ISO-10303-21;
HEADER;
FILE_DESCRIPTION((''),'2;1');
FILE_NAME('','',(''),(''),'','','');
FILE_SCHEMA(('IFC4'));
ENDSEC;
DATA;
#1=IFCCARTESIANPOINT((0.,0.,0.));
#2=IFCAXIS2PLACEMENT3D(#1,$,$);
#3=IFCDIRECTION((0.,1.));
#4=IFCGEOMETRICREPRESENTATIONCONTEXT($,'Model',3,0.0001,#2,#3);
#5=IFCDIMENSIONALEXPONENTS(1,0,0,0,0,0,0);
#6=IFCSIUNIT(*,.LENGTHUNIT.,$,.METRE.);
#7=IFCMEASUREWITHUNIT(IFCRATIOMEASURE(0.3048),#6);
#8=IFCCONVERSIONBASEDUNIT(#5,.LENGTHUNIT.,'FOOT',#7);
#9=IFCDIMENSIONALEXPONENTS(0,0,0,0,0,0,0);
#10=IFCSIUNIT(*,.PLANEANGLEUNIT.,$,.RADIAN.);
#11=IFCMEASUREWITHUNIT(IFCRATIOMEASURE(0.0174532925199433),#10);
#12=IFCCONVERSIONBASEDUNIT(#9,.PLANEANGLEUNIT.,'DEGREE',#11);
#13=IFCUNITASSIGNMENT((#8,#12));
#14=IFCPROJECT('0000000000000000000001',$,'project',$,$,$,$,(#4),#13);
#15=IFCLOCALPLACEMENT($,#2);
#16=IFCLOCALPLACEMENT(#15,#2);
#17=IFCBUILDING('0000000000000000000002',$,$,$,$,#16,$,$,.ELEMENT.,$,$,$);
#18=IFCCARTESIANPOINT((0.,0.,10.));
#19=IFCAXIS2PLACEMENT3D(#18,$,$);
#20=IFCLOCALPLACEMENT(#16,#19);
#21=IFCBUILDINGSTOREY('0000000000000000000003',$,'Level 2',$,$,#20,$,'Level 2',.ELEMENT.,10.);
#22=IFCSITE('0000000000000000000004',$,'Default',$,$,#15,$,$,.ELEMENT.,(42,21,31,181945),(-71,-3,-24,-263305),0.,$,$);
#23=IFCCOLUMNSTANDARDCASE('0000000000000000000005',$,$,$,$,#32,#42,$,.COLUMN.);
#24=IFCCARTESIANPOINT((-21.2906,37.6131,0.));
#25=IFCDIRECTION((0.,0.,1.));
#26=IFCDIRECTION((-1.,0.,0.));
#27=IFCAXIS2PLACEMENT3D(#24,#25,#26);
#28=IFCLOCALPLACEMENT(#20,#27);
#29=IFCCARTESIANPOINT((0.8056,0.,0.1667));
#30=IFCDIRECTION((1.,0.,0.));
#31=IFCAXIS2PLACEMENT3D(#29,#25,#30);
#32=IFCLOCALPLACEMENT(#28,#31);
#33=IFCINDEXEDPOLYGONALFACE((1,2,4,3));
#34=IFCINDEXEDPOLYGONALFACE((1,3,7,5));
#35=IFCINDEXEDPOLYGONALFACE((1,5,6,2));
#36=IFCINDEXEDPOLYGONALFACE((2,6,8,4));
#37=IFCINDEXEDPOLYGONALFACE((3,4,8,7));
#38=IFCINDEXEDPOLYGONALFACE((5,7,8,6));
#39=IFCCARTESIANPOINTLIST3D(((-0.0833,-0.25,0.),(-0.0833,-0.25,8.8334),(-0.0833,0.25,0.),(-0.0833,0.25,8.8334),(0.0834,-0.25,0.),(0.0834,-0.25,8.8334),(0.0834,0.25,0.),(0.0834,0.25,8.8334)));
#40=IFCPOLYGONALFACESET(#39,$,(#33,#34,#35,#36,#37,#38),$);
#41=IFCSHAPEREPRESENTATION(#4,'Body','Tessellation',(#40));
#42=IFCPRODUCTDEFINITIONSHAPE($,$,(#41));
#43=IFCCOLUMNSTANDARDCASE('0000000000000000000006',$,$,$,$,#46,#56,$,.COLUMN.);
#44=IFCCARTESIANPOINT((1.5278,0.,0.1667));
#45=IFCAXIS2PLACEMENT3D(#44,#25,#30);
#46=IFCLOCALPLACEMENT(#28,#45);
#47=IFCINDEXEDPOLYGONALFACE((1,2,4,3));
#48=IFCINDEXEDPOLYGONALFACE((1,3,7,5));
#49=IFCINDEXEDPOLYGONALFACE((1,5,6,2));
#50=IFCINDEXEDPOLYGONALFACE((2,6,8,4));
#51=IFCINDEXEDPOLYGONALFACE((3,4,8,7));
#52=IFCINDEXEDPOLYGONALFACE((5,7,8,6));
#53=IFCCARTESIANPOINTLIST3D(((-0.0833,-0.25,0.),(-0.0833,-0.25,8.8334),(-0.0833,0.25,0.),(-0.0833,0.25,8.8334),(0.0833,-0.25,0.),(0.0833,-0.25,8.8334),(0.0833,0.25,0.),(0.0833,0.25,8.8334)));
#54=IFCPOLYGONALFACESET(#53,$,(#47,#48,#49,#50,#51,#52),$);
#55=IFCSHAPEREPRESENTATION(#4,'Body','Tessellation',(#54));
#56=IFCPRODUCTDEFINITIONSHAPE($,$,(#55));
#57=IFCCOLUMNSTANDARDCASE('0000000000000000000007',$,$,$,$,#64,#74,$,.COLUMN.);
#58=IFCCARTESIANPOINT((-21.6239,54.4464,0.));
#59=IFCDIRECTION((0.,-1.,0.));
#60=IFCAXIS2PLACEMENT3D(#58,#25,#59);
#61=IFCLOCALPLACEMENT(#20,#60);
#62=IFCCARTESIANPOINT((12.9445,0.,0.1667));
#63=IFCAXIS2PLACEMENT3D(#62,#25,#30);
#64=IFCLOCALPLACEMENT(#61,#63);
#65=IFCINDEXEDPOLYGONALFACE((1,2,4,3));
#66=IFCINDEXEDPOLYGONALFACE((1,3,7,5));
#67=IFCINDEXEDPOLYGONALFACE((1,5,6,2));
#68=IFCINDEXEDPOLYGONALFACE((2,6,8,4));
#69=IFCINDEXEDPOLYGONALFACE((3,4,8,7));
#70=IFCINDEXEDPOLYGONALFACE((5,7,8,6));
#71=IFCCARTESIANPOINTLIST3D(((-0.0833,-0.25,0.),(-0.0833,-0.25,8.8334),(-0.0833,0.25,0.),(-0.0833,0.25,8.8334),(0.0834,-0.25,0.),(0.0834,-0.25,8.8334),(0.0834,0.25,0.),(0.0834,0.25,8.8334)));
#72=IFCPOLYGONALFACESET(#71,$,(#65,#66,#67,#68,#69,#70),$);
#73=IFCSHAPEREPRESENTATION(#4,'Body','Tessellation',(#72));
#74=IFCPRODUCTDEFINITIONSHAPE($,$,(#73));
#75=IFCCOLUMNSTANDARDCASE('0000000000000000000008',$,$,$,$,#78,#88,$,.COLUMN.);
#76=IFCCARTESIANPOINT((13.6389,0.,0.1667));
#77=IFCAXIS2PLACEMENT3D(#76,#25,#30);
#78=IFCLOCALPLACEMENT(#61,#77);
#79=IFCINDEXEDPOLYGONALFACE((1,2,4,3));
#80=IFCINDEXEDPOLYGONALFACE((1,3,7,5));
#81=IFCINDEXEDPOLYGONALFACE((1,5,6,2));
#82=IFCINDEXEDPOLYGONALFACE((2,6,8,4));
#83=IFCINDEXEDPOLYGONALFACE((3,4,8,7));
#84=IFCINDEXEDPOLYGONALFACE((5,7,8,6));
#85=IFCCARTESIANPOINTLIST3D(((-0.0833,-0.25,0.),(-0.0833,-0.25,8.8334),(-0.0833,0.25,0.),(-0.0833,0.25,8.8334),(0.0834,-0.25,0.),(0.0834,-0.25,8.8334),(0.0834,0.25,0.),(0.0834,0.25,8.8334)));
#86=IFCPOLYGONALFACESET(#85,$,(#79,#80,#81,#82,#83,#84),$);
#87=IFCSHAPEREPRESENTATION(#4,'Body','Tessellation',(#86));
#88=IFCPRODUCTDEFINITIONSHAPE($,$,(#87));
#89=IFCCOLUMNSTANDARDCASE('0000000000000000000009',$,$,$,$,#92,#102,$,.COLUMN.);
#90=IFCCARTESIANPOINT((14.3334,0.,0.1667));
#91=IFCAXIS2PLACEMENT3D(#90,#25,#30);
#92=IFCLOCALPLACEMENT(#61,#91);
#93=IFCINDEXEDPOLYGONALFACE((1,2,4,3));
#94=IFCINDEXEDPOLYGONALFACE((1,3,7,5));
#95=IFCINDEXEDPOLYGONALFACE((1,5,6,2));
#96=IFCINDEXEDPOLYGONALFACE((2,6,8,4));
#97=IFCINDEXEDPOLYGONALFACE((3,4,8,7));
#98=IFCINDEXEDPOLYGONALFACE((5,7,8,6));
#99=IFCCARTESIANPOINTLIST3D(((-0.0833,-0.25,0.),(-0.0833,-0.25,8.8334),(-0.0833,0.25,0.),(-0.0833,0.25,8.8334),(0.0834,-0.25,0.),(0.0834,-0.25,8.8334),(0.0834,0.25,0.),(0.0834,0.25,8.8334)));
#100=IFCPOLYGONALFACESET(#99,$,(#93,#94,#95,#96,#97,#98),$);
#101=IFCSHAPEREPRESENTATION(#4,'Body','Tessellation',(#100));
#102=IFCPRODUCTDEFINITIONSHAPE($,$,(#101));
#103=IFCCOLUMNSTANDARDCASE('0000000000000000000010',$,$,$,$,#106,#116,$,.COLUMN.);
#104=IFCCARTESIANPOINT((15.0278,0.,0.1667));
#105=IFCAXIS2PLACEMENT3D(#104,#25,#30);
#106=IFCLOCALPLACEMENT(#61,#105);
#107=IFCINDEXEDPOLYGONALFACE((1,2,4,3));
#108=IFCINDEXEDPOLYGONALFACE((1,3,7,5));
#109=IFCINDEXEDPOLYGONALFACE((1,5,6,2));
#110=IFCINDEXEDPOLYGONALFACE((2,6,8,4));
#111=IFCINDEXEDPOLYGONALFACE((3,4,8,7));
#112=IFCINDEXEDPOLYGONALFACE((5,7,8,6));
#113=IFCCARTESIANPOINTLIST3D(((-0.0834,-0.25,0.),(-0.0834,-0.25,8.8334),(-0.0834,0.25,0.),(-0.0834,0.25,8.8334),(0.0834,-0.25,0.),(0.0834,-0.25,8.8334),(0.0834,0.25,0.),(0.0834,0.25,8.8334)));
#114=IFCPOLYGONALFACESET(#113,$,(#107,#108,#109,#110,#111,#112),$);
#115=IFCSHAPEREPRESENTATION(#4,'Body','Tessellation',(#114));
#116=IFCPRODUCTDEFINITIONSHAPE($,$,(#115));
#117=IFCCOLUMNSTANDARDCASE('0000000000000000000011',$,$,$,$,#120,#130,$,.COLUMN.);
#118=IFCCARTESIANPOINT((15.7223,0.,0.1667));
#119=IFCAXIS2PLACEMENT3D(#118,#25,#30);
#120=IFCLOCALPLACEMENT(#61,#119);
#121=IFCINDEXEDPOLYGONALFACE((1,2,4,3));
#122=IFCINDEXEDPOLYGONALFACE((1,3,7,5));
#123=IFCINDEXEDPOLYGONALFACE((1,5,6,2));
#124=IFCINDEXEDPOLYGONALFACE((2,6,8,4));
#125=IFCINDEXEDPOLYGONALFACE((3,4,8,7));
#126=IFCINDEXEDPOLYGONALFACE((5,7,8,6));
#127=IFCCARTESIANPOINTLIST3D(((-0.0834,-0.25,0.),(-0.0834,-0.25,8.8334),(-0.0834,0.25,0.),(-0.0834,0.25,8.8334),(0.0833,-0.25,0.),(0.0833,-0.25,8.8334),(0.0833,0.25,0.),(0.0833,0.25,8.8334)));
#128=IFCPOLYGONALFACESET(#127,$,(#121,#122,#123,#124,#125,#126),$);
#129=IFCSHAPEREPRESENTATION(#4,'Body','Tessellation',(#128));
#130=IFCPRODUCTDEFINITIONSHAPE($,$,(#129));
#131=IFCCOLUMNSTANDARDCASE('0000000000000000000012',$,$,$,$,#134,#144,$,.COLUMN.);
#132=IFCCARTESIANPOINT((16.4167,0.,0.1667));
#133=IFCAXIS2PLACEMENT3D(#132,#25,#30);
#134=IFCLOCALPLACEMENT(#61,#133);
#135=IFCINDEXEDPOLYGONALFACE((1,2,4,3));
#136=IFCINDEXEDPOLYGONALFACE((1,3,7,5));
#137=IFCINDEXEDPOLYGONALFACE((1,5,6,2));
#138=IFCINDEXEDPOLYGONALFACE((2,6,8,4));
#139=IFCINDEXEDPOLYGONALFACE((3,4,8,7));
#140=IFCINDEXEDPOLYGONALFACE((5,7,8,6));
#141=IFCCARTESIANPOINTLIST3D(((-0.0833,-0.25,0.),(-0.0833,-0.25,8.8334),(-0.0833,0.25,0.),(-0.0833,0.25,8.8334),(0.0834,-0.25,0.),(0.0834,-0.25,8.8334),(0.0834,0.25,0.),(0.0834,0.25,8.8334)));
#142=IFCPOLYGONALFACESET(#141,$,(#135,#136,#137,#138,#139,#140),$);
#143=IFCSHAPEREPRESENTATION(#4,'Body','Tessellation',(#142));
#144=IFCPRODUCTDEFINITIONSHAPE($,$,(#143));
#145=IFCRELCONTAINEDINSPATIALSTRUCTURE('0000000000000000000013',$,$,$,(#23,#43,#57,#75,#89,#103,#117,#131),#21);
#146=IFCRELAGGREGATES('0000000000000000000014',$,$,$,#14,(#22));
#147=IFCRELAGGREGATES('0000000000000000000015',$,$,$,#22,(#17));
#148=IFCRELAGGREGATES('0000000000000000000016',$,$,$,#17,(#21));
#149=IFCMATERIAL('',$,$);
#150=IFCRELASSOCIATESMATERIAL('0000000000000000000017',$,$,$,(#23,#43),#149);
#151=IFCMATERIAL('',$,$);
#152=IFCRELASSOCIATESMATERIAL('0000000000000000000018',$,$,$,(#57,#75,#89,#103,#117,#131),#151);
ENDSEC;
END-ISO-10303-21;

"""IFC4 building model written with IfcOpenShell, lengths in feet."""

from ifc_helpers import new_model, entity, si_unit, converted_unit, direction, frame, origin, place, context, project, spatial, rectangle, extrude, material, element, save


model = new_model("IFC4")

# Units and contexts
model_context = context("Model", 3, precision=0.0001, world=origin(), true_north=direction((0.0, 1.0)))
ifc_project = project(units=[converted_unit("LENGTHUNIT", "FOOT", entity("IfcRatioMeasure", 0.3048), si_unit("LENGTHUNIT", "METRE"), dimensions=[1, 0, 0, 0, 0, 0, 0]), converted_unit("PLANEANGLEUNIT", "DEGREE", entity("IfcRatioMeasure", 0.0174532925199433), si_unit("PLANEANGLEUNIT", "RADIAN"), dimensions=[0, 0, 0, 0, 0, 0, 0])], contexts=[model_context])

# Site, building, storey
site_placement = place(None, origin())
site = spatial("IfcSite", under=ifc_project, at=site_placement, Name="Default", CompositionType="ELEMENT", RefLatitude=(42, 21, 31, 181945), RefLongitude=(-71, -3, -24, -263305), RefElevation=0.0)
building_placement = place(site_placement, origin())
building = spatial("IfcBuilding", under=site, at=building_placement, CompositionType="ELEMENT")
storey_placement = place(building_placement, frame((0.0, 0.0, 10.0)))
storey = spatial("IfcBuildingStorey", under=building, at=storey_placement, Name="Level 2", LongName="Level 2", CompositionType="ELEMENT", Elevation=10.0)

# Columns
ifc_material_1 = material(Name="")
placement_1 = place(storey_placement, frame((-21.2906, 37.6131, 0.0), z_axis=(0.0, 0.0, 1.0), x_axis=(-1.0, 0.0, 0.0)))
for number, where, z_axis, x_axis in (
    (1, (0.8056, 0.0, 0.1667), (0.0, 0.0, 1.0), (1.0, 0.0, 0.0)),
    (2, (1.5278, 0.0, 0.1667), (0.0, 0.0, 1.0), (1.0, 0.0, 0.0)),
):
    element("IfcColumnStandardCase", number, at=place(placement_1, frame(where, z_axis=z_axis, x_axis=x_axis)), inside=storey, material=ifc_material_1, PredefinedType="COLUMN", context=model_context, shape_type="SweptSolid", body=[
        extrude(rectangle(XDim=0.1667, YDim=0.5), origin(), (0.0, 0.0, 1.0), 8.8334),
    ])
ifc_material_2 = material(Name="")
placement_2 = place(storey_placement, frame((-21.6239, 54.4464, 0.0), z_axis=(0.0, 0.0, 1.0), x_axis=(0.0, -1.0, 0.0)))
for number, where, z_axis, x_axis in (
    (3, (12.9445, 0.0, 0.1667), (0.0, 0.0, 1.0), (1.0, 0.0, 0.0)),
    (4, (13.6389, 0.0, 0.1667), (0.0, 0.0, 1.0), (1.0, 0.0, 0.0)),
    (5, (14.3334, 0.0, 0.1667), (0.0, 0.0, 1.0), (1.0, 0.0, 0.0)),
    (6, (15.0278, 0.0, 0.1667), (0.0, 0.0, 1.0), (1.0, 0.0, 0.0)),
    (7, (15.7223, 0.0, 0.1667), (0.0, 0.0, 1.0), (1.0, 0.0, 0.0)),
    (8, (16.4167, 0.0, 0.1667), (0.0, 0.0, 1.0), (1.0, 0.0, 0.0)),
):
    element("IfcColumnStandardCase", number, at=place(placement_2, frame(where, z_axis=z_axis, x_axis=x_axis)), inside=storey, material=ifc_material_2, PredefinedType="COLUMN", context=model_context, shape_type="SweptSolid", body=[
        extrude(rectangle(XDim=0.1667, YDim=0.5), origin(), (0.0, 0.0, 1.0), 8.8334),
    ])

save(model, "model.ifc")
